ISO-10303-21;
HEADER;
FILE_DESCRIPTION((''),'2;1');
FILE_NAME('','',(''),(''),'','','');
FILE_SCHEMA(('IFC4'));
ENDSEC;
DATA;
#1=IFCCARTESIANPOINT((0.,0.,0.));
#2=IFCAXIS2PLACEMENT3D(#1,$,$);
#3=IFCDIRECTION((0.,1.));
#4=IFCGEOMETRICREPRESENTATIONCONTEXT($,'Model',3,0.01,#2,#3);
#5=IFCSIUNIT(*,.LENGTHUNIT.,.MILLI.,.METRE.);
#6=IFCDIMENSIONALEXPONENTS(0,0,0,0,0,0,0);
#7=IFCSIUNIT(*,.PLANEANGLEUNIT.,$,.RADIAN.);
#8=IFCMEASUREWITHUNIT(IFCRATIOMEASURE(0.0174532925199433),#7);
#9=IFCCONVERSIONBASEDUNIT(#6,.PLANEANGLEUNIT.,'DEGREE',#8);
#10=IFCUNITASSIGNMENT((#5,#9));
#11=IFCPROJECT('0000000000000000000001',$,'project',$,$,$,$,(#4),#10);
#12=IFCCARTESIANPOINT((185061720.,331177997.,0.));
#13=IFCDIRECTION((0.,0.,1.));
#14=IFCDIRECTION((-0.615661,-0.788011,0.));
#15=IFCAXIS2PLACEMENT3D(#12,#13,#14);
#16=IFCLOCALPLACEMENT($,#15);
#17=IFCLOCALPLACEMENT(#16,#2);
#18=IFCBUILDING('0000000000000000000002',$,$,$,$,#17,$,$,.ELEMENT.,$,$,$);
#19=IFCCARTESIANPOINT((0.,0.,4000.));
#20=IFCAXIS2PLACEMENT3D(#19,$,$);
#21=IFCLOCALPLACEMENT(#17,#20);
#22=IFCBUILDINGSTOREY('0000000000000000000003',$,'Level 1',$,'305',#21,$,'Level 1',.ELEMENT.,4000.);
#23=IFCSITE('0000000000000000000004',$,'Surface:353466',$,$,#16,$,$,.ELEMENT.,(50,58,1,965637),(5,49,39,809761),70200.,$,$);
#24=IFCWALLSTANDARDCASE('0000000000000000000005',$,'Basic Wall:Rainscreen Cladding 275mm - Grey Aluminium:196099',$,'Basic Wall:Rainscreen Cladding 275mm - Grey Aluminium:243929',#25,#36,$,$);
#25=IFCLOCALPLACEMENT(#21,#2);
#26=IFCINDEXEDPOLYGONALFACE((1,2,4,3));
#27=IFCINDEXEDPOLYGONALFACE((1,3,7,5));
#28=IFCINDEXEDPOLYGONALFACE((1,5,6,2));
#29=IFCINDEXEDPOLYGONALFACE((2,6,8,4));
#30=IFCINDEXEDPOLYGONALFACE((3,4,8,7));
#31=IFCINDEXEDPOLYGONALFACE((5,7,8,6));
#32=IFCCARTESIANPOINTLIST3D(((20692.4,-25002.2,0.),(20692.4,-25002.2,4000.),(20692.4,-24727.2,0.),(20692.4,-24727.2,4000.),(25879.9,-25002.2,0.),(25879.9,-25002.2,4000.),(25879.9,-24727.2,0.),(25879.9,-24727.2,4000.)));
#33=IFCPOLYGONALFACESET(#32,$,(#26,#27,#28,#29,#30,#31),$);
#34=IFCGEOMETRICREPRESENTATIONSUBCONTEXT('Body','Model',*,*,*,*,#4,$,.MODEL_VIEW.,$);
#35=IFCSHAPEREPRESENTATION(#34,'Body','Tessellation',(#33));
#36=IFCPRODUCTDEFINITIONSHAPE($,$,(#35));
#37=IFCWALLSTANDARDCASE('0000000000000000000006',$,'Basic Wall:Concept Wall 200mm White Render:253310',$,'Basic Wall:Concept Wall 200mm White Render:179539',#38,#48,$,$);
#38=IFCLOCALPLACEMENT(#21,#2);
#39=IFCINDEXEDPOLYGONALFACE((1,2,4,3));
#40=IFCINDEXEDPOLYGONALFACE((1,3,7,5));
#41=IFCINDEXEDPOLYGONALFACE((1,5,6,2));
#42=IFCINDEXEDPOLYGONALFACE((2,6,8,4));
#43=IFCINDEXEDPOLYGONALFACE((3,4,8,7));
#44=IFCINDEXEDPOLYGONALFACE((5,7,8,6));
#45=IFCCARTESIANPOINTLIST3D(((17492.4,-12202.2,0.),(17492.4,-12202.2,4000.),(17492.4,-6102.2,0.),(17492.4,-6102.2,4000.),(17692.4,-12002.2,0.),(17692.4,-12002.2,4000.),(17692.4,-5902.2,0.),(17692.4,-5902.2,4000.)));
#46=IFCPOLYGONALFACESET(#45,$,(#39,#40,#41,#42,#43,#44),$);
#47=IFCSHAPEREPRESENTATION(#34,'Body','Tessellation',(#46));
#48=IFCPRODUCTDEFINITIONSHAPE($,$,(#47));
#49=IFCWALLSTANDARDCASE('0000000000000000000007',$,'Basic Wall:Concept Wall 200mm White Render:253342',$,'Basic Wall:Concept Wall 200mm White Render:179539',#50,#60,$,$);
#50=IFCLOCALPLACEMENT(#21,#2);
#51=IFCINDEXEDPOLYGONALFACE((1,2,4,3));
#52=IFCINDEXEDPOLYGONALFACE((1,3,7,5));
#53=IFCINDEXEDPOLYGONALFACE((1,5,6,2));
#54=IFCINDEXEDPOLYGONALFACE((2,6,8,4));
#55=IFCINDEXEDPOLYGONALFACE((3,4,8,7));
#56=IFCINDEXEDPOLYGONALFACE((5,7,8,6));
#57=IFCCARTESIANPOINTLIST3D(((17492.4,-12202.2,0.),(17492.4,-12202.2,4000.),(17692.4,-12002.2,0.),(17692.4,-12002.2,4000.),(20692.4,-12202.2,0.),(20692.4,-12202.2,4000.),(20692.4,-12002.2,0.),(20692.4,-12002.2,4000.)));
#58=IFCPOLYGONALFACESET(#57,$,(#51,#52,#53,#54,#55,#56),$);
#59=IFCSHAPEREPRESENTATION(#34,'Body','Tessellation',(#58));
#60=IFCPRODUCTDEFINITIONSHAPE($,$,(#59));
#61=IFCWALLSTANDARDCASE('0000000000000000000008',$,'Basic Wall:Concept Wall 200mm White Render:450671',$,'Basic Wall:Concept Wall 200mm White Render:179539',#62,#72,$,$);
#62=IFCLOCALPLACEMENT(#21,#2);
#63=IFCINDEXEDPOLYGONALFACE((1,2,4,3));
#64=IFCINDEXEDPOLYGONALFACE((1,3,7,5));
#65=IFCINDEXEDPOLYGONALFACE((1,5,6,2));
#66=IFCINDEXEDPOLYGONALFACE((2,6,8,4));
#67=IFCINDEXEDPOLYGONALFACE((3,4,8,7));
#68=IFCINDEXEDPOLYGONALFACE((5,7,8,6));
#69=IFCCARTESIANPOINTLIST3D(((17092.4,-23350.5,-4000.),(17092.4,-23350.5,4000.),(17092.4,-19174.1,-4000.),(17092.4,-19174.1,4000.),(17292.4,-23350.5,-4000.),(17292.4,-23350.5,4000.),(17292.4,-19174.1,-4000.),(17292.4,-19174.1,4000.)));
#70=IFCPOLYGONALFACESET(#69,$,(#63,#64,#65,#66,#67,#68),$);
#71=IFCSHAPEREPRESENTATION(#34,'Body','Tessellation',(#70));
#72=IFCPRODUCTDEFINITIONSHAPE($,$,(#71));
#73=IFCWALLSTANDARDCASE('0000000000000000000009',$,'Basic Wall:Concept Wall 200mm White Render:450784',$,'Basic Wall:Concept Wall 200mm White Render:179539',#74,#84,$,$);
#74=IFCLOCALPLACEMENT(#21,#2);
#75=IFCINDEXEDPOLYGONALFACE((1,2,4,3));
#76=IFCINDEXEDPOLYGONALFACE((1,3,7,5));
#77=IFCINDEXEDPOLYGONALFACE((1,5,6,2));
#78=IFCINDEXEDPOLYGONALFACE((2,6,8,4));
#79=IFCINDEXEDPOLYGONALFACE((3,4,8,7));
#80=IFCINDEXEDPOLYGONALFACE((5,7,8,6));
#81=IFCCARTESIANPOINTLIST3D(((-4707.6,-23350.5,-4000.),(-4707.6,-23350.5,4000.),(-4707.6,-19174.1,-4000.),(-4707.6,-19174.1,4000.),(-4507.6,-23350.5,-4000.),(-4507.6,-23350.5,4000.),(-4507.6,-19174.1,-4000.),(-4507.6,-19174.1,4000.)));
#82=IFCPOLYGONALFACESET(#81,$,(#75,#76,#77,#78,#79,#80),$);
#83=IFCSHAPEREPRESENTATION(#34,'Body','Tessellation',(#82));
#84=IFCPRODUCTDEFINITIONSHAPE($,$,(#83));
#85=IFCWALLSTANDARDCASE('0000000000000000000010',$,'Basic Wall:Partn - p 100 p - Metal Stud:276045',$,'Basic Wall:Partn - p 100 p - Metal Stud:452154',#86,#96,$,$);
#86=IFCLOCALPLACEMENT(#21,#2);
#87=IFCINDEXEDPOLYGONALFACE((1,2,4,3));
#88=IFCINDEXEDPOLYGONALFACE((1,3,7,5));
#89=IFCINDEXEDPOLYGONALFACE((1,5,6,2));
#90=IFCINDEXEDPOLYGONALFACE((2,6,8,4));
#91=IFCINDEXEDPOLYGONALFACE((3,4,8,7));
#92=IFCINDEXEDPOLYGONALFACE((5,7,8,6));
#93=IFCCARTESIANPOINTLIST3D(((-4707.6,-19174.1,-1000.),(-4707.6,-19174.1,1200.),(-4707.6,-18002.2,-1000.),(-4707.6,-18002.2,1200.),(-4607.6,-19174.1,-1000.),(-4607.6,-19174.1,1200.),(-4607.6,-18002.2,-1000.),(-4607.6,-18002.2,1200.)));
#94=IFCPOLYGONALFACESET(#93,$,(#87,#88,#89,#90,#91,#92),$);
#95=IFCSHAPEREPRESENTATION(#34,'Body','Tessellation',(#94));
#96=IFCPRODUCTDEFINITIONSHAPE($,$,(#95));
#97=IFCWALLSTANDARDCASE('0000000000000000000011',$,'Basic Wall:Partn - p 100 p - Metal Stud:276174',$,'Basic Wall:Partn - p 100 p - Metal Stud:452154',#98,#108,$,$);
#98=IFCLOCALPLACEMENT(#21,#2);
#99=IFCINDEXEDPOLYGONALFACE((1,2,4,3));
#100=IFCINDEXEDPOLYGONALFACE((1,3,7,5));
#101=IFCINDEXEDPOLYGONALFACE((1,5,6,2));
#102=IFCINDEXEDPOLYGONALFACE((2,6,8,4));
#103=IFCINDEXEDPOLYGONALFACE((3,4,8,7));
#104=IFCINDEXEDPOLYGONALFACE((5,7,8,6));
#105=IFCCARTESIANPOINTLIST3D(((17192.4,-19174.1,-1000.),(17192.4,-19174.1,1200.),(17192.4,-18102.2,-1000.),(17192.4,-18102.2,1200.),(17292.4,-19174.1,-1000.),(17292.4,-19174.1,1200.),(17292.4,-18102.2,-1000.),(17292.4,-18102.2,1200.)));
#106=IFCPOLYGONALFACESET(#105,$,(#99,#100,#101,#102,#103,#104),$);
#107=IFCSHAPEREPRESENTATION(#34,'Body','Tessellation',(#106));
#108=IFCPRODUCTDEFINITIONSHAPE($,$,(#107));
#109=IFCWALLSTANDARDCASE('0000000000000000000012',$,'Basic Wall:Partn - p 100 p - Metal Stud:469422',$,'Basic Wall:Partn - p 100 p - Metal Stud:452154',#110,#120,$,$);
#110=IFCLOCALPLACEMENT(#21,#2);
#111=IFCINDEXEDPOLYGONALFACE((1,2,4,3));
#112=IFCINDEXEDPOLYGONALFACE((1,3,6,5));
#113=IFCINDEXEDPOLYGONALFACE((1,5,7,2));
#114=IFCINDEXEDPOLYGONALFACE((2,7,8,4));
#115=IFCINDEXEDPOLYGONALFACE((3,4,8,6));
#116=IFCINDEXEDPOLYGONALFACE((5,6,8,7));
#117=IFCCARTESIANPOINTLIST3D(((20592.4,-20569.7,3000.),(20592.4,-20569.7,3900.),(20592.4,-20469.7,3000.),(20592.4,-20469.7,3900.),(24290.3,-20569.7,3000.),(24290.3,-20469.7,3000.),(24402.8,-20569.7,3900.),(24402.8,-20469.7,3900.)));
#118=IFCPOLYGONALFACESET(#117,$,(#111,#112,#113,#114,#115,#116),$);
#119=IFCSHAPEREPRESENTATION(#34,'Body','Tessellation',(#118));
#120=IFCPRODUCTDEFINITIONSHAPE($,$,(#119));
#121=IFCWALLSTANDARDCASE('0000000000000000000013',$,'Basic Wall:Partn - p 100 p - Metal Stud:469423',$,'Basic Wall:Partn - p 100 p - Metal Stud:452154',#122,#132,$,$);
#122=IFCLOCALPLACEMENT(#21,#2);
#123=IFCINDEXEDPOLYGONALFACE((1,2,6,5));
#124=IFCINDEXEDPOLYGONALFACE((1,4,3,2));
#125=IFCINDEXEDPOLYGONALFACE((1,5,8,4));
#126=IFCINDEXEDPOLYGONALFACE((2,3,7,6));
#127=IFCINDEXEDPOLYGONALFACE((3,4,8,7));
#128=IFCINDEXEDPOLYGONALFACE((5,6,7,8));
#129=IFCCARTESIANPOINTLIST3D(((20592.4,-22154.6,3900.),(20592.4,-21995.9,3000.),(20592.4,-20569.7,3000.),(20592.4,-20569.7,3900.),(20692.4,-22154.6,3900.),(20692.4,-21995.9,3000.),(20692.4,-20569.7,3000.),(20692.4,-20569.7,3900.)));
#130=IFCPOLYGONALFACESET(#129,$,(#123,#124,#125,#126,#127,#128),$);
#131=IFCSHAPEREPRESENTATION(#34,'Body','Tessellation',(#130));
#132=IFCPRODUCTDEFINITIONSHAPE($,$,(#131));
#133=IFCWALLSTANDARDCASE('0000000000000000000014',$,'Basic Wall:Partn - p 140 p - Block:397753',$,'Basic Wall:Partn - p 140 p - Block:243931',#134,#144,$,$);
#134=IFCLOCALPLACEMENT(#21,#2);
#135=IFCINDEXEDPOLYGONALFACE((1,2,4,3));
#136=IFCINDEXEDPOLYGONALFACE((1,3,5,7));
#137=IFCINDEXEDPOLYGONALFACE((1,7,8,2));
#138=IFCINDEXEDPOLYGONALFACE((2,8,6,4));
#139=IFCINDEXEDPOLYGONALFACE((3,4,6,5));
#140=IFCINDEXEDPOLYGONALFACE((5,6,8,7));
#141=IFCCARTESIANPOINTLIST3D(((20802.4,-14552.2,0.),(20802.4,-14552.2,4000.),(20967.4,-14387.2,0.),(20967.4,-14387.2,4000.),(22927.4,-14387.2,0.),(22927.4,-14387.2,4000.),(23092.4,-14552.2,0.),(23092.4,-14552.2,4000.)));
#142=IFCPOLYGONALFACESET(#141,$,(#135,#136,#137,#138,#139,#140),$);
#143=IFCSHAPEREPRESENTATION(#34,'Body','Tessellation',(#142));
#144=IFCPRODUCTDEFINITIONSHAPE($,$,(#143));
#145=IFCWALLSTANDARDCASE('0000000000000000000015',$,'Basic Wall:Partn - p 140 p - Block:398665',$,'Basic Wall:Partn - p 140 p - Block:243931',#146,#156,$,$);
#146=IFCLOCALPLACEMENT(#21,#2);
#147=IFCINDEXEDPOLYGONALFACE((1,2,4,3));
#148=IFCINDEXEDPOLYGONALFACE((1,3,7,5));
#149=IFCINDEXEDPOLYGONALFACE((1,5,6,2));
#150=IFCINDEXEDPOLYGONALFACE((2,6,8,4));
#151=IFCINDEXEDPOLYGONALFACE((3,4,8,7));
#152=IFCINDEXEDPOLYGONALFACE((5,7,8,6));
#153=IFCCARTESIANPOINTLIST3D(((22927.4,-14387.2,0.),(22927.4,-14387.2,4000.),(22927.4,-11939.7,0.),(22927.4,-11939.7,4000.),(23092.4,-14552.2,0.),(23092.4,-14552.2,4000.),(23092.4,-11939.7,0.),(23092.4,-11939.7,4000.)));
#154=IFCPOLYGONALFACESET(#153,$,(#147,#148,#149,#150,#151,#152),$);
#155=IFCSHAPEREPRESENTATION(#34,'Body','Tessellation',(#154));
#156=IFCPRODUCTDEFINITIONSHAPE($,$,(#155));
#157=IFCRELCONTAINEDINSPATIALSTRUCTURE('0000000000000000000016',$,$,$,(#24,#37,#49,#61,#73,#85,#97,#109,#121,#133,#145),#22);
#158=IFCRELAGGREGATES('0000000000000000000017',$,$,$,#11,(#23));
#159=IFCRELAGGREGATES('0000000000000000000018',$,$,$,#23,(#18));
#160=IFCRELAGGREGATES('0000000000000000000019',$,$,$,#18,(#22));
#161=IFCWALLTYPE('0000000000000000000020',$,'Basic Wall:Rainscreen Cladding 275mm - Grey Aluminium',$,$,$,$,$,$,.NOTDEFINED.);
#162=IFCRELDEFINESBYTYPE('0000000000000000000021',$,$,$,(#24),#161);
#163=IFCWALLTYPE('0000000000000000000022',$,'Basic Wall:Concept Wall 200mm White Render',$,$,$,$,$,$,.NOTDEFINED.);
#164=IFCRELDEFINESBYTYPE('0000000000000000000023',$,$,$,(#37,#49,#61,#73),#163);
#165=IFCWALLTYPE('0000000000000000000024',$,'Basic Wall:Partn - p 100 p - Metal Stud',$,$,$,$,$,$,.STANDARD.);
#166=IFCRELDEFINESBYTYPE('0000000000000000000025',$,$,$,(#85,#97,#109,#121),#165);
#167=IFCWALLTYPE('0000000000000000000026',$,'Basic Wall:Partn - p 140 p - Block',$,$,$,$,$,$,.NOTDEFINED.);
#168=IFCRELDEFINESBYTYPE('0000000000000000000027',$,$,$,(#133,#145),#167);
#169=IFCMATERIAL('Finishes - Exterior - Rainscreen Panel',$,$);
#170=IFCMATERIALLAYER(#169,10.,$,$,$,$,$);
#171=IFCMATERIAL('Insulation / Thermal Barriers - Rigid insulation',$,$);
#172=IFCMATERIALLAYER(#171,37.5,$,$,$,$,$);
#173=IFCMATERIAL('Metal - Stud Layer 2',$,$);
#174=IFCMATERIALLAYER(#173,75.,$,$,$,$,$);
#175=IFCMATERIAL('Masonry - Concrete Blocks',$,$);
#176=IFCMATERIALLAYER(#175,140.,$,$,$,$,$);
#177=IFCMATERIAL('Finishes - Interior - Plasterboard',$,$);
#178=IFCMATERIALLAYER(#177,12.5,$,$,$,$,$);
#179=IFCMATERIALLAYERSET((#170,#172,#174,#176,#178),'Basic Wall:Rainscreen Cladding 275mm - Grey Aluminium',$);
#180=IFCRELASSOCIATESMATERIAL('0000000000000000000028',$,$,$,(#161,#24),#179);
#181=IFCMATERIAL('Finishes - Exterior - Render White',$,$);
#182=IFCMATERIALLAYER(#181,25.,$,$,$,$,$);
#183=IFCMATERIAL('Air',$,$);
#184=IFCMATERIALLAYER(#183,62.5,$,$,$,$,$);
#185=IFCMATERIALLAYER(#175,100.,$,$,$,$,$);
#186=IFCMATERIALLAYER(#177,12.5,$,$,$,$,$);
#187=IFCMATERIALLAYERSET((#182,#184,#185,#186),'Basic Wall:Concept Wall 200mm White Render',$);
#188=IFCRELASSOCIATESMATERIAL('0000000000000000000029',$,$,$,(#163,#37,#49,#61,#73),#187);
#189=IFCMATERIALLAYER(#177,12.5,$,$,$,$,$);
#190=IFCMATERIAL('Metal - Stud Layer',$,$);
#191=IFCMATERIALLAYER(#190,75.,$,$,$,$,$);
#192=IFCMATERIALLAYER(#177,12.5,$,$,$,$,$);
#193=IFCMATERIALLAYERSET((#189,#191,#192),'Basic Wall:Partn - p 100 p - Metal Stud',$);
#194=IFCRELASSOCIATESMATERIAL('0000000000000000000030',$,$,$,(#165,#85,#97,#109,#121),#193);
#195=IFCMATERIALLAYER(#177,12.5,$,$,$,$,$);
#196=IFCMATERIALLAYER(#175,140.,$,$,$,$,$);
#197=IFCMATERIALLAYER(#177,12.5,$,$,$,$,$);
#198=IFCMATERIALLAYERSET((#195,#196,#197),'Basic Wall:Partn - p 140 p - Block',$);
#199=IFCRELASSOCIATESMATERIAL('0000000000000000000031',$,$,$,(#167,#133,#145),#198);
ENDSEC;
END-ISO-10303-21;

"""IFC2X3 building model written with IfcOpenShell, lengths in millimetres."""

from ifc_helpers import new_model, entity, si_unit, converted_unit, direction, frame, frame_2d, origin, place, context, subcontext, project, spatial, polyline, rectangle, outline, extrude, clip, halfspace, material, layer, layer_set, layer_usage, type_object, element, save


model = new_model("IFC2X3")

# Units and contexts
model_context = context("Model", 3, precision=0.01, world=origin(), true_north=direction((0.0, 1.0)))
body_context = subcontext(model_context, "Body", "Model", "MODEL_VIEW")
ifc_project = project(units=[si_unit("LENGTHUNIT", "METRE", prefix="MILLI"), converted_unit("PLANEANGLEUNIT", "DEGREE", entity("IfcRatioMeasure", 0.0174532925199433), si_unit("PLANEANGLEUNIT", "RADIAN"), dimensions=[0, 0, 0, 0, 0, 0, 0])], contexts=[model_context])

# Site, building, storey
site_placement = place(None, frame((185061720.0, 331177997.0, 0.0), z_axis=(0.0, 0.0, 1.0), x_axis=(-0.615661, -0.788011, 0.0)))
site = spatial("IfcSite", under=ifc_project, at=site_placement, Name="Surface:353466", CompositionType="ELEMENT", RefLatitude=(50, 58, 1, 965637), RefLongitude=(5, 49, 39, 809761), RefElevation=70200.0)
building_placement = place(site_placement, origin())
building = spatial("IfcBuilding", under=site, at=building_placement, CompositionType="ELEMENT")
storey_placement = place(building_placement, frame((0.0, 0.0, 4000.0)))
storey = spatial("IfcBuildingStorey", under=building, at=storey_placement, Name="Level 1", ObjectType="305", LongName="Level 1", CompositionType="ELEMENT", Elevation=4000.0)

# Walls
ifc_material_1 = material(Name="Finishes - Exterior - Rainscreen Panel")
ifc_layer_1 = layer(ifc_material_1, 10.0)
ifc_material_2 = material(Name="Insulation / Thermal Barriers - Rigid insulation")
ifc_layer_2 = layer(ifc_material_2, 37.5)
ifc_material_3 = material(Name="Metal - Stud Layer 2")
ifc_layer_3 = layer(ifc_material_3, 75.0)
ifc_material_4 = material(Name="Masonry - Concrete Blocks")
ifc_layer_4 = layer(ifc_material_4, 140.0)
ifc_material_5 = material(Name="Finishes - Interior - Plasterboard")
ifc_layer_5 = layer(ifc_material_5, 12.5)
ifc_layer_set_1 = layer_set([ifc_layer_1, ifc_layer_2, ifc_layer_3, ifc_layer_4, ifc_layer_5], Name="Basic Wall:Rainscreen Cladding 275mm - Grey Aluminium")
ifc_layer_usage_1 = layer_usage(ifc_layer_set_1, "AXIS2", "POSITIVE", -137.5)
wall_type_1 = type_object("IfcWallType", Name="Basic Wall:Rainscreen Cladding 275mm - Grey Aluminium", PredefinedType="NOTDEFINED", material=ifc_layer_set_1)
wall_1_placement = place(storey_placement, frame((20692.4, -24864.7, 0.0)))
element("IfcWallStandardCase", 1, at=wall_1_placement, inside=storey, type_object=wall_type_1, material=ifc_layer_usage_1, Name="Basic Wall:Rainscreen Cladding 275mm - Grey Aluminium:196099", ObjectType="Basic Wall:Rainscreen Cladding 275mm - Grey Aluminium:243929", context=body_context, shape_type="Clipping", body=[
    clip(extrude(rectangle(XDim=5187.5, YDim=275.0, at=frame_2d((2593.8, 0.0), x_axis=(-1.0, 0.0))), origin(), (0.0, 0.0, 1.0), 4000.0), halfspace(frame((0.0, 0.0, -4000.0)), True)),
])
ifc_material_6 = material(Name="Finishes - Exterior - Render White")
ifc_layer_6 = layer(ifc_material_6, 25.0)
ifc_material_7 = material(Name="Air")
ifc_layer_7 = layer(ifc_material_7, 62.5)
ifc_layer_8 = layer(ifc_material_4, 100.0)
ifc_layer_9 = layer(ifc_material_5, 12.5)
ifc_layer_set_2 = layer_set([ifc_layer_6, ifc_layer_7, ifc_layer_8, ifc_layer_9], Name="Basic Wall:Concept Wall 200mm White Render")
ifc_layer_usage_2 = layer_usage(ifc_layer_set_2, "AXIS2", "NEGATIVE", 100.0)
wall_type_2 = type_object("IfcWallType", Name="Basic Wall:Concept Wall 200mm White Render", PredefinedType="NOTDEFINED", material=ifc_layer_set_2)
wall_2_placement = place(storey_placement, frame((17592.4, -5902.2, 0.0), z_axis=(0.0, 0.0, 1.0), x_axis=(0.0, -1.0, 0.0)))
element("IfcWallStandardCase", 2, at=wall_2_placement, inside=storey, type_object=wall_type_2, material=ifc_layer_usage_2, Name="Basic Wall:Concept Wall 200mm White Render:253310", ObjectType="Basic Wall:Concept Wall 200mm White Render:179539", context=body_context, shape_type="Clipping", body=[
    clip(extrude(outline(polyline([(6300.0, -100.0), (6100.0, 100.0), (0.0, 100.0), (200.0, -100.0), (6300.0, -100.0)])), origin(), (0.0, 0.0, 1.0), 4000.0), halfspace(frame((0.0, 0.0, -4000.0)), True)),
])
ifc_layer_usage_3 = layer_usage(ifc_layer_set_2, "AXIS2", "NEGATIVE", 100.0)
wall_3_placement = place(storey_placement, frame((17492.4, -12102.2, 0.0)))
element("IfcWallStandardCase", 3, at=wall_3_placement, inside=storey, type_object=wall_type_2, material=ifc_layer_usage_3, Name="Basic Wall:Concept Wall 200mm White Render:253342", ObjectType="Basic Wall:Concept Wall 200mm White Render:179539", context=body_context, shape_type="Clipping", body=[
    clip(extrude(outline(polyline([(0.0, -100.0), (3200.0, -100.0), (3200.0, 100.0), (200.0, 100.0), (0.0, -100.0)])), origin(), (0.0, 0.0, 1.0), 4000.0), halfspace(frame((0.0, 0.0, -4000.0)), True)),
])
ifc_layer_usage_4 = layer_usage(ifc_layer_set_2, "AXIS2", "NEGATIVE", 100.0)
wall_4_placement = place(storey_placement, frame((17192.4, -23350.5, -4000.0), z_axis=(0.0, 0.0, 1.0), x_axis=(0.0, 1.0, 0.0)))
element("IfcWallStandardCase", 4, at=wall_4_placement, inside=storey, type_object=wall_type_2, material=ifc_layer_usage_4, Name="Basic Wall:Concept Wall 200mm White Render:450671", ObjectType="Basic Wall:Concept Wall 200mm White Render:179539", context=body_context, shape_type="Clipping", body=[
    clip(extrude(rectangle(XDim=4176.4, YDim=200.0, at=frame_2d((2088.2, 0.0), x_axis=(-1.0, 0.0))), origin(), (0.0, 0.0, 1.0), 8000.0), halfspace(frame((0.0, 0.0, -4000.0)), True)),
])
ifc_layer_usage_5 = layer_usage(ifc_layer_set_2, "AXIS2", "POSITIVE", -100.0)
wall_5_placement = place(storey_placement, frame((-4607.6, -23350.5, -4000.0), z_axis=(0.0, 0.0, 1.0), x_axis=(0.0, 1.0, 0.0)))
element("IfcWallStandardCase", 5, at=wall_5_placement, inside=storey, type_object=wall_type_2, material=ifc_layer_usage_5, Name="Basic Wall:Concept Wall 200mm White Render:450784", ObjectType="Basic Wall:Concept Wall 200mm White Render:179539", context=body_context, shape_type="Clipping", body=[
    clip(extrude(rectangle(XDim=4176.4, YDim=200.0, at=frame_2d((2088.2, 0.0), x_axis=(-1.0, 0.0))), origin(), (0.0, 0.0, 1.0), 8000.0), halfspace(frame((0.0, 0.0, -4000.0)), True)),
])
ifc_layer_10 = layer(ifc_material_5, 12.5)
ifc_material_8 = material(Name="Metal - Stud Layer")
ifc_layer_11 = layer(ifc_material_8, 75.0)
ifc_layer_12 = layer(ifc_material_5, 12.5)
ifc_layer_set_3 = layer_set([ifc_layer_10, ifc_layer_11, ifc_layer_12], Name="Basic Wall:Partn - p 100 p - Metal Stud")
ifc_layer_usage_6 = layer_usage(ifc_layer_set_3, "AXIS2", "POSITIVE", -50.0)
wall_type_3 = type_object("IfcWallType", Name="Basic Wall:Partn - p 100 p - Metal Stud", PredefinedType="STANDARD", material=ifc_layer_set_3)
wall_6_placement = place(storey_placement, frame((-4657.6, -19174.1, -1000.0), z_axis=(0.0, 0.0, 1.0), x_axis=(0.0, 1.0, 0.0)))
element("IfcWallStandardCase", 6, at=wall_6_placement, inside=storey, type_object=wall_type_3, material=ifc_layer_usage_6, Name="Basic Wall:Partn - p 100 p - Metal Stud:276045", ObjectType="Basic Wall:Partn - p 100 p - Metal Stud:452154", context=body_context, shape_type="SweptSolid", body=[
    extrude(rectangle(XDim=1171.9, YDim=100.0, at=frame_2d((586.0, 0.0), x_axis=(-1.0, 0.0))), origin(), (0.0, 0.0, 1.0), 2200.0),
])
ifc_layer_usage_7 = layer_usage(ifc_layer_set_3, "AXIS2", "POSITIVE", -50.0)
wall_7_placement = place(storey_placement, frame((17242.4, -18102.2, -1000.0), z_axis=(0.0, 0.0, 1.0), x_axis=(0.0, -1.0, 0.0)))
element("IfcWallStandardCase", 7, at=wall_7_placement, inside=storey, type_object=wall_type_3, material=ifc_layer_usage_7, Name="Basic Wall:Partn - p 100 p - Metal Stud:276174", ObjectType="Basic Wall:Partn - p 100 p - Metal Stud:452154", context=body_context, shape_type="SweptSolid", body=[
    extrude(rectangle(XDim=1071.9, YDim=100.0, at=frame_2d((536.0, 0.0), x_axis=(-1.0, 0.0))), origin(), (0.0, 0.0, 1.0), 2200.0),
])
ifc_layer_usage_8 = layer_usage(ifc_layer_set_3, "AXIS2", "POSITIVE", -50.0)
wall_8_placement = place(storey_placement, frame((24402.8, -20519.7, 3000.0), z_axis=(0.0, 0.0, 1.0), x_axis=(-1.0, 0.0, 0.0)))
element("IfcWallStandardCase", 8, at=wall_8_placement, inside=storey, type_object=wall_type_3, material=ifc_layer_usage_8, Name="Basic Wall:Partn - p 100 p - Metal Stud:469422", ObjectType="Basic Wall:Partn - p 100 p - Metal Stud:452154", context=body_context, shape_type="Clipping", body=[
    clip(extrude(rectangle(XDim=3810.4, YDim=100.0, at=frame_2d((1905.2, 0.0), x_axis=(-1.0, 0.0))), origin(), (0.0, 0.0, 1.0), 900.0), halfspace(frame((112.5, -50.0, 0.0), z_axis=(-0.992278, 0.0, -0.124035), x_axis=(0.0, 1.0, 0.0)), False)),
])
ifc_layer_usage_9 = layer_usage(ifc_layer_set_3, "AXIS2", "POSITIVE", -50.0)
wall_9_placement = place(storey_placement, frame((20642.4, -20569.7, 3000.0), z_axis=(0.0, 0.0, 1.0), x_axis=(0.0, -1.0, 0.0)))
element("IfcWallStandardCase", 9, at=wall_9_placement, inside=storey, type_object=wall_type_3, material=ifc_layer_usage_9, Name="Basic Wall:Partn - p 100 p - Metal Stud:469423", ObjectType="Basic Wall:Partn - p 100 p - Metal Stud:452154", context=body_context, shape_type="Clipping", body=[
    clip(extrude(rectangle(XDim=1584.9, YDim=100.0, at=frame_2d((792.4, 0.0), x_axis=(-1.0, 0.0))), origin(), (0.0, 0.0, 1.0), 900.0), halfspace(frame((1584.9, -50.0, 900.0), z_axis=(0.984808, 0.0, -0.173648), x_axis=(0.0, 1.0, 0.0)), False)),
])

# Walls
ifc_layer_13 = layer(ifc_material_5, 12.5)
ifc_layer_14 = layer(ifc_material_4, 140.0)
ifc_layer_15 = layer(ifc_material_5, 12.5)
ifc_layer_set_4 = layer_set([ifc_layer_13, ifc_layer_14, ifc_layer_15], Name="Basic Wall:Partn - p 140 p - Block")
ifc_layer_usage_10 = layer_usage(ifc_layer_set_4, "AXIS2", "NEGATIVE", 82.5)
wall_type_4 = type_object("IfcWallType", Name="Basic Wall:Partn - p 140 p - Block", PredefinedType="NOTDEFINED", material=ifc_layer_set_4)
wall_10_placement = place(storey_placement, frame((23092.4, -14469.7, 0.0), z_axis=(0.0, 0.0, 1.0), x_axis=(-1.0, 0.0, 0.0)))
element("IfcWallStandardCase", 10, at=wall_10_placement, inside=storey, type_object=wall_type_4, material=ifc_layer_usage_10, Name="Basic Wall:Partn - p 140 p - Block:397753", ObjectType="Basic Wall:Partn - p 140 p - Block:243931", context=body_context, shape_type="Clipping", body=[
    clip(extrude(outline(polyline([(2125.0, -82.5), (2290.0, 82.5), (0.0, 82.5), (165.0, -82.5), (2125.0, -82.5)])), origin(), (0.0, 0.0, 1.0), 4000.0), halfspace(frame((0.0, 0.0, -4000.0)), True)),
])
ifc_layer_usage_11 = layer_usage(ifc_layer_set_4, "AXIS2", "NEGATIVE", 82.5)
wall_11_placement = place(storey_placement, frame((23009.9, -14552.2, 0.0), z_axis=(0.0, 0.0, 1.0), x_axis=(0.0, 1.0, 0.0)))
element("IfcWallStandardCase", 11, at=wall_11_placement, inside=storey, type_object=wall_type_4, material=ifc_layer_usage_11, Name="Basic Wall:Partn - p 140 p - Block:398665", ObjectType="Basic Wall:Partn - p 140 p - Block:243931", context=body_context, shape_type="Clipping", body=[
    clip(extrude(outline(polyline([(2612.5, -82.5), (2612.5, 82.5), (165.0, 82.5), (0.0, -82.5), (2612.5, -82.5)])), origin(), (0.0, 0.0, 1.0), 4000.0), halfspace(frame((0.0, 0.0, -4000.0)), True)),
])

save(model, "model.ifc")
